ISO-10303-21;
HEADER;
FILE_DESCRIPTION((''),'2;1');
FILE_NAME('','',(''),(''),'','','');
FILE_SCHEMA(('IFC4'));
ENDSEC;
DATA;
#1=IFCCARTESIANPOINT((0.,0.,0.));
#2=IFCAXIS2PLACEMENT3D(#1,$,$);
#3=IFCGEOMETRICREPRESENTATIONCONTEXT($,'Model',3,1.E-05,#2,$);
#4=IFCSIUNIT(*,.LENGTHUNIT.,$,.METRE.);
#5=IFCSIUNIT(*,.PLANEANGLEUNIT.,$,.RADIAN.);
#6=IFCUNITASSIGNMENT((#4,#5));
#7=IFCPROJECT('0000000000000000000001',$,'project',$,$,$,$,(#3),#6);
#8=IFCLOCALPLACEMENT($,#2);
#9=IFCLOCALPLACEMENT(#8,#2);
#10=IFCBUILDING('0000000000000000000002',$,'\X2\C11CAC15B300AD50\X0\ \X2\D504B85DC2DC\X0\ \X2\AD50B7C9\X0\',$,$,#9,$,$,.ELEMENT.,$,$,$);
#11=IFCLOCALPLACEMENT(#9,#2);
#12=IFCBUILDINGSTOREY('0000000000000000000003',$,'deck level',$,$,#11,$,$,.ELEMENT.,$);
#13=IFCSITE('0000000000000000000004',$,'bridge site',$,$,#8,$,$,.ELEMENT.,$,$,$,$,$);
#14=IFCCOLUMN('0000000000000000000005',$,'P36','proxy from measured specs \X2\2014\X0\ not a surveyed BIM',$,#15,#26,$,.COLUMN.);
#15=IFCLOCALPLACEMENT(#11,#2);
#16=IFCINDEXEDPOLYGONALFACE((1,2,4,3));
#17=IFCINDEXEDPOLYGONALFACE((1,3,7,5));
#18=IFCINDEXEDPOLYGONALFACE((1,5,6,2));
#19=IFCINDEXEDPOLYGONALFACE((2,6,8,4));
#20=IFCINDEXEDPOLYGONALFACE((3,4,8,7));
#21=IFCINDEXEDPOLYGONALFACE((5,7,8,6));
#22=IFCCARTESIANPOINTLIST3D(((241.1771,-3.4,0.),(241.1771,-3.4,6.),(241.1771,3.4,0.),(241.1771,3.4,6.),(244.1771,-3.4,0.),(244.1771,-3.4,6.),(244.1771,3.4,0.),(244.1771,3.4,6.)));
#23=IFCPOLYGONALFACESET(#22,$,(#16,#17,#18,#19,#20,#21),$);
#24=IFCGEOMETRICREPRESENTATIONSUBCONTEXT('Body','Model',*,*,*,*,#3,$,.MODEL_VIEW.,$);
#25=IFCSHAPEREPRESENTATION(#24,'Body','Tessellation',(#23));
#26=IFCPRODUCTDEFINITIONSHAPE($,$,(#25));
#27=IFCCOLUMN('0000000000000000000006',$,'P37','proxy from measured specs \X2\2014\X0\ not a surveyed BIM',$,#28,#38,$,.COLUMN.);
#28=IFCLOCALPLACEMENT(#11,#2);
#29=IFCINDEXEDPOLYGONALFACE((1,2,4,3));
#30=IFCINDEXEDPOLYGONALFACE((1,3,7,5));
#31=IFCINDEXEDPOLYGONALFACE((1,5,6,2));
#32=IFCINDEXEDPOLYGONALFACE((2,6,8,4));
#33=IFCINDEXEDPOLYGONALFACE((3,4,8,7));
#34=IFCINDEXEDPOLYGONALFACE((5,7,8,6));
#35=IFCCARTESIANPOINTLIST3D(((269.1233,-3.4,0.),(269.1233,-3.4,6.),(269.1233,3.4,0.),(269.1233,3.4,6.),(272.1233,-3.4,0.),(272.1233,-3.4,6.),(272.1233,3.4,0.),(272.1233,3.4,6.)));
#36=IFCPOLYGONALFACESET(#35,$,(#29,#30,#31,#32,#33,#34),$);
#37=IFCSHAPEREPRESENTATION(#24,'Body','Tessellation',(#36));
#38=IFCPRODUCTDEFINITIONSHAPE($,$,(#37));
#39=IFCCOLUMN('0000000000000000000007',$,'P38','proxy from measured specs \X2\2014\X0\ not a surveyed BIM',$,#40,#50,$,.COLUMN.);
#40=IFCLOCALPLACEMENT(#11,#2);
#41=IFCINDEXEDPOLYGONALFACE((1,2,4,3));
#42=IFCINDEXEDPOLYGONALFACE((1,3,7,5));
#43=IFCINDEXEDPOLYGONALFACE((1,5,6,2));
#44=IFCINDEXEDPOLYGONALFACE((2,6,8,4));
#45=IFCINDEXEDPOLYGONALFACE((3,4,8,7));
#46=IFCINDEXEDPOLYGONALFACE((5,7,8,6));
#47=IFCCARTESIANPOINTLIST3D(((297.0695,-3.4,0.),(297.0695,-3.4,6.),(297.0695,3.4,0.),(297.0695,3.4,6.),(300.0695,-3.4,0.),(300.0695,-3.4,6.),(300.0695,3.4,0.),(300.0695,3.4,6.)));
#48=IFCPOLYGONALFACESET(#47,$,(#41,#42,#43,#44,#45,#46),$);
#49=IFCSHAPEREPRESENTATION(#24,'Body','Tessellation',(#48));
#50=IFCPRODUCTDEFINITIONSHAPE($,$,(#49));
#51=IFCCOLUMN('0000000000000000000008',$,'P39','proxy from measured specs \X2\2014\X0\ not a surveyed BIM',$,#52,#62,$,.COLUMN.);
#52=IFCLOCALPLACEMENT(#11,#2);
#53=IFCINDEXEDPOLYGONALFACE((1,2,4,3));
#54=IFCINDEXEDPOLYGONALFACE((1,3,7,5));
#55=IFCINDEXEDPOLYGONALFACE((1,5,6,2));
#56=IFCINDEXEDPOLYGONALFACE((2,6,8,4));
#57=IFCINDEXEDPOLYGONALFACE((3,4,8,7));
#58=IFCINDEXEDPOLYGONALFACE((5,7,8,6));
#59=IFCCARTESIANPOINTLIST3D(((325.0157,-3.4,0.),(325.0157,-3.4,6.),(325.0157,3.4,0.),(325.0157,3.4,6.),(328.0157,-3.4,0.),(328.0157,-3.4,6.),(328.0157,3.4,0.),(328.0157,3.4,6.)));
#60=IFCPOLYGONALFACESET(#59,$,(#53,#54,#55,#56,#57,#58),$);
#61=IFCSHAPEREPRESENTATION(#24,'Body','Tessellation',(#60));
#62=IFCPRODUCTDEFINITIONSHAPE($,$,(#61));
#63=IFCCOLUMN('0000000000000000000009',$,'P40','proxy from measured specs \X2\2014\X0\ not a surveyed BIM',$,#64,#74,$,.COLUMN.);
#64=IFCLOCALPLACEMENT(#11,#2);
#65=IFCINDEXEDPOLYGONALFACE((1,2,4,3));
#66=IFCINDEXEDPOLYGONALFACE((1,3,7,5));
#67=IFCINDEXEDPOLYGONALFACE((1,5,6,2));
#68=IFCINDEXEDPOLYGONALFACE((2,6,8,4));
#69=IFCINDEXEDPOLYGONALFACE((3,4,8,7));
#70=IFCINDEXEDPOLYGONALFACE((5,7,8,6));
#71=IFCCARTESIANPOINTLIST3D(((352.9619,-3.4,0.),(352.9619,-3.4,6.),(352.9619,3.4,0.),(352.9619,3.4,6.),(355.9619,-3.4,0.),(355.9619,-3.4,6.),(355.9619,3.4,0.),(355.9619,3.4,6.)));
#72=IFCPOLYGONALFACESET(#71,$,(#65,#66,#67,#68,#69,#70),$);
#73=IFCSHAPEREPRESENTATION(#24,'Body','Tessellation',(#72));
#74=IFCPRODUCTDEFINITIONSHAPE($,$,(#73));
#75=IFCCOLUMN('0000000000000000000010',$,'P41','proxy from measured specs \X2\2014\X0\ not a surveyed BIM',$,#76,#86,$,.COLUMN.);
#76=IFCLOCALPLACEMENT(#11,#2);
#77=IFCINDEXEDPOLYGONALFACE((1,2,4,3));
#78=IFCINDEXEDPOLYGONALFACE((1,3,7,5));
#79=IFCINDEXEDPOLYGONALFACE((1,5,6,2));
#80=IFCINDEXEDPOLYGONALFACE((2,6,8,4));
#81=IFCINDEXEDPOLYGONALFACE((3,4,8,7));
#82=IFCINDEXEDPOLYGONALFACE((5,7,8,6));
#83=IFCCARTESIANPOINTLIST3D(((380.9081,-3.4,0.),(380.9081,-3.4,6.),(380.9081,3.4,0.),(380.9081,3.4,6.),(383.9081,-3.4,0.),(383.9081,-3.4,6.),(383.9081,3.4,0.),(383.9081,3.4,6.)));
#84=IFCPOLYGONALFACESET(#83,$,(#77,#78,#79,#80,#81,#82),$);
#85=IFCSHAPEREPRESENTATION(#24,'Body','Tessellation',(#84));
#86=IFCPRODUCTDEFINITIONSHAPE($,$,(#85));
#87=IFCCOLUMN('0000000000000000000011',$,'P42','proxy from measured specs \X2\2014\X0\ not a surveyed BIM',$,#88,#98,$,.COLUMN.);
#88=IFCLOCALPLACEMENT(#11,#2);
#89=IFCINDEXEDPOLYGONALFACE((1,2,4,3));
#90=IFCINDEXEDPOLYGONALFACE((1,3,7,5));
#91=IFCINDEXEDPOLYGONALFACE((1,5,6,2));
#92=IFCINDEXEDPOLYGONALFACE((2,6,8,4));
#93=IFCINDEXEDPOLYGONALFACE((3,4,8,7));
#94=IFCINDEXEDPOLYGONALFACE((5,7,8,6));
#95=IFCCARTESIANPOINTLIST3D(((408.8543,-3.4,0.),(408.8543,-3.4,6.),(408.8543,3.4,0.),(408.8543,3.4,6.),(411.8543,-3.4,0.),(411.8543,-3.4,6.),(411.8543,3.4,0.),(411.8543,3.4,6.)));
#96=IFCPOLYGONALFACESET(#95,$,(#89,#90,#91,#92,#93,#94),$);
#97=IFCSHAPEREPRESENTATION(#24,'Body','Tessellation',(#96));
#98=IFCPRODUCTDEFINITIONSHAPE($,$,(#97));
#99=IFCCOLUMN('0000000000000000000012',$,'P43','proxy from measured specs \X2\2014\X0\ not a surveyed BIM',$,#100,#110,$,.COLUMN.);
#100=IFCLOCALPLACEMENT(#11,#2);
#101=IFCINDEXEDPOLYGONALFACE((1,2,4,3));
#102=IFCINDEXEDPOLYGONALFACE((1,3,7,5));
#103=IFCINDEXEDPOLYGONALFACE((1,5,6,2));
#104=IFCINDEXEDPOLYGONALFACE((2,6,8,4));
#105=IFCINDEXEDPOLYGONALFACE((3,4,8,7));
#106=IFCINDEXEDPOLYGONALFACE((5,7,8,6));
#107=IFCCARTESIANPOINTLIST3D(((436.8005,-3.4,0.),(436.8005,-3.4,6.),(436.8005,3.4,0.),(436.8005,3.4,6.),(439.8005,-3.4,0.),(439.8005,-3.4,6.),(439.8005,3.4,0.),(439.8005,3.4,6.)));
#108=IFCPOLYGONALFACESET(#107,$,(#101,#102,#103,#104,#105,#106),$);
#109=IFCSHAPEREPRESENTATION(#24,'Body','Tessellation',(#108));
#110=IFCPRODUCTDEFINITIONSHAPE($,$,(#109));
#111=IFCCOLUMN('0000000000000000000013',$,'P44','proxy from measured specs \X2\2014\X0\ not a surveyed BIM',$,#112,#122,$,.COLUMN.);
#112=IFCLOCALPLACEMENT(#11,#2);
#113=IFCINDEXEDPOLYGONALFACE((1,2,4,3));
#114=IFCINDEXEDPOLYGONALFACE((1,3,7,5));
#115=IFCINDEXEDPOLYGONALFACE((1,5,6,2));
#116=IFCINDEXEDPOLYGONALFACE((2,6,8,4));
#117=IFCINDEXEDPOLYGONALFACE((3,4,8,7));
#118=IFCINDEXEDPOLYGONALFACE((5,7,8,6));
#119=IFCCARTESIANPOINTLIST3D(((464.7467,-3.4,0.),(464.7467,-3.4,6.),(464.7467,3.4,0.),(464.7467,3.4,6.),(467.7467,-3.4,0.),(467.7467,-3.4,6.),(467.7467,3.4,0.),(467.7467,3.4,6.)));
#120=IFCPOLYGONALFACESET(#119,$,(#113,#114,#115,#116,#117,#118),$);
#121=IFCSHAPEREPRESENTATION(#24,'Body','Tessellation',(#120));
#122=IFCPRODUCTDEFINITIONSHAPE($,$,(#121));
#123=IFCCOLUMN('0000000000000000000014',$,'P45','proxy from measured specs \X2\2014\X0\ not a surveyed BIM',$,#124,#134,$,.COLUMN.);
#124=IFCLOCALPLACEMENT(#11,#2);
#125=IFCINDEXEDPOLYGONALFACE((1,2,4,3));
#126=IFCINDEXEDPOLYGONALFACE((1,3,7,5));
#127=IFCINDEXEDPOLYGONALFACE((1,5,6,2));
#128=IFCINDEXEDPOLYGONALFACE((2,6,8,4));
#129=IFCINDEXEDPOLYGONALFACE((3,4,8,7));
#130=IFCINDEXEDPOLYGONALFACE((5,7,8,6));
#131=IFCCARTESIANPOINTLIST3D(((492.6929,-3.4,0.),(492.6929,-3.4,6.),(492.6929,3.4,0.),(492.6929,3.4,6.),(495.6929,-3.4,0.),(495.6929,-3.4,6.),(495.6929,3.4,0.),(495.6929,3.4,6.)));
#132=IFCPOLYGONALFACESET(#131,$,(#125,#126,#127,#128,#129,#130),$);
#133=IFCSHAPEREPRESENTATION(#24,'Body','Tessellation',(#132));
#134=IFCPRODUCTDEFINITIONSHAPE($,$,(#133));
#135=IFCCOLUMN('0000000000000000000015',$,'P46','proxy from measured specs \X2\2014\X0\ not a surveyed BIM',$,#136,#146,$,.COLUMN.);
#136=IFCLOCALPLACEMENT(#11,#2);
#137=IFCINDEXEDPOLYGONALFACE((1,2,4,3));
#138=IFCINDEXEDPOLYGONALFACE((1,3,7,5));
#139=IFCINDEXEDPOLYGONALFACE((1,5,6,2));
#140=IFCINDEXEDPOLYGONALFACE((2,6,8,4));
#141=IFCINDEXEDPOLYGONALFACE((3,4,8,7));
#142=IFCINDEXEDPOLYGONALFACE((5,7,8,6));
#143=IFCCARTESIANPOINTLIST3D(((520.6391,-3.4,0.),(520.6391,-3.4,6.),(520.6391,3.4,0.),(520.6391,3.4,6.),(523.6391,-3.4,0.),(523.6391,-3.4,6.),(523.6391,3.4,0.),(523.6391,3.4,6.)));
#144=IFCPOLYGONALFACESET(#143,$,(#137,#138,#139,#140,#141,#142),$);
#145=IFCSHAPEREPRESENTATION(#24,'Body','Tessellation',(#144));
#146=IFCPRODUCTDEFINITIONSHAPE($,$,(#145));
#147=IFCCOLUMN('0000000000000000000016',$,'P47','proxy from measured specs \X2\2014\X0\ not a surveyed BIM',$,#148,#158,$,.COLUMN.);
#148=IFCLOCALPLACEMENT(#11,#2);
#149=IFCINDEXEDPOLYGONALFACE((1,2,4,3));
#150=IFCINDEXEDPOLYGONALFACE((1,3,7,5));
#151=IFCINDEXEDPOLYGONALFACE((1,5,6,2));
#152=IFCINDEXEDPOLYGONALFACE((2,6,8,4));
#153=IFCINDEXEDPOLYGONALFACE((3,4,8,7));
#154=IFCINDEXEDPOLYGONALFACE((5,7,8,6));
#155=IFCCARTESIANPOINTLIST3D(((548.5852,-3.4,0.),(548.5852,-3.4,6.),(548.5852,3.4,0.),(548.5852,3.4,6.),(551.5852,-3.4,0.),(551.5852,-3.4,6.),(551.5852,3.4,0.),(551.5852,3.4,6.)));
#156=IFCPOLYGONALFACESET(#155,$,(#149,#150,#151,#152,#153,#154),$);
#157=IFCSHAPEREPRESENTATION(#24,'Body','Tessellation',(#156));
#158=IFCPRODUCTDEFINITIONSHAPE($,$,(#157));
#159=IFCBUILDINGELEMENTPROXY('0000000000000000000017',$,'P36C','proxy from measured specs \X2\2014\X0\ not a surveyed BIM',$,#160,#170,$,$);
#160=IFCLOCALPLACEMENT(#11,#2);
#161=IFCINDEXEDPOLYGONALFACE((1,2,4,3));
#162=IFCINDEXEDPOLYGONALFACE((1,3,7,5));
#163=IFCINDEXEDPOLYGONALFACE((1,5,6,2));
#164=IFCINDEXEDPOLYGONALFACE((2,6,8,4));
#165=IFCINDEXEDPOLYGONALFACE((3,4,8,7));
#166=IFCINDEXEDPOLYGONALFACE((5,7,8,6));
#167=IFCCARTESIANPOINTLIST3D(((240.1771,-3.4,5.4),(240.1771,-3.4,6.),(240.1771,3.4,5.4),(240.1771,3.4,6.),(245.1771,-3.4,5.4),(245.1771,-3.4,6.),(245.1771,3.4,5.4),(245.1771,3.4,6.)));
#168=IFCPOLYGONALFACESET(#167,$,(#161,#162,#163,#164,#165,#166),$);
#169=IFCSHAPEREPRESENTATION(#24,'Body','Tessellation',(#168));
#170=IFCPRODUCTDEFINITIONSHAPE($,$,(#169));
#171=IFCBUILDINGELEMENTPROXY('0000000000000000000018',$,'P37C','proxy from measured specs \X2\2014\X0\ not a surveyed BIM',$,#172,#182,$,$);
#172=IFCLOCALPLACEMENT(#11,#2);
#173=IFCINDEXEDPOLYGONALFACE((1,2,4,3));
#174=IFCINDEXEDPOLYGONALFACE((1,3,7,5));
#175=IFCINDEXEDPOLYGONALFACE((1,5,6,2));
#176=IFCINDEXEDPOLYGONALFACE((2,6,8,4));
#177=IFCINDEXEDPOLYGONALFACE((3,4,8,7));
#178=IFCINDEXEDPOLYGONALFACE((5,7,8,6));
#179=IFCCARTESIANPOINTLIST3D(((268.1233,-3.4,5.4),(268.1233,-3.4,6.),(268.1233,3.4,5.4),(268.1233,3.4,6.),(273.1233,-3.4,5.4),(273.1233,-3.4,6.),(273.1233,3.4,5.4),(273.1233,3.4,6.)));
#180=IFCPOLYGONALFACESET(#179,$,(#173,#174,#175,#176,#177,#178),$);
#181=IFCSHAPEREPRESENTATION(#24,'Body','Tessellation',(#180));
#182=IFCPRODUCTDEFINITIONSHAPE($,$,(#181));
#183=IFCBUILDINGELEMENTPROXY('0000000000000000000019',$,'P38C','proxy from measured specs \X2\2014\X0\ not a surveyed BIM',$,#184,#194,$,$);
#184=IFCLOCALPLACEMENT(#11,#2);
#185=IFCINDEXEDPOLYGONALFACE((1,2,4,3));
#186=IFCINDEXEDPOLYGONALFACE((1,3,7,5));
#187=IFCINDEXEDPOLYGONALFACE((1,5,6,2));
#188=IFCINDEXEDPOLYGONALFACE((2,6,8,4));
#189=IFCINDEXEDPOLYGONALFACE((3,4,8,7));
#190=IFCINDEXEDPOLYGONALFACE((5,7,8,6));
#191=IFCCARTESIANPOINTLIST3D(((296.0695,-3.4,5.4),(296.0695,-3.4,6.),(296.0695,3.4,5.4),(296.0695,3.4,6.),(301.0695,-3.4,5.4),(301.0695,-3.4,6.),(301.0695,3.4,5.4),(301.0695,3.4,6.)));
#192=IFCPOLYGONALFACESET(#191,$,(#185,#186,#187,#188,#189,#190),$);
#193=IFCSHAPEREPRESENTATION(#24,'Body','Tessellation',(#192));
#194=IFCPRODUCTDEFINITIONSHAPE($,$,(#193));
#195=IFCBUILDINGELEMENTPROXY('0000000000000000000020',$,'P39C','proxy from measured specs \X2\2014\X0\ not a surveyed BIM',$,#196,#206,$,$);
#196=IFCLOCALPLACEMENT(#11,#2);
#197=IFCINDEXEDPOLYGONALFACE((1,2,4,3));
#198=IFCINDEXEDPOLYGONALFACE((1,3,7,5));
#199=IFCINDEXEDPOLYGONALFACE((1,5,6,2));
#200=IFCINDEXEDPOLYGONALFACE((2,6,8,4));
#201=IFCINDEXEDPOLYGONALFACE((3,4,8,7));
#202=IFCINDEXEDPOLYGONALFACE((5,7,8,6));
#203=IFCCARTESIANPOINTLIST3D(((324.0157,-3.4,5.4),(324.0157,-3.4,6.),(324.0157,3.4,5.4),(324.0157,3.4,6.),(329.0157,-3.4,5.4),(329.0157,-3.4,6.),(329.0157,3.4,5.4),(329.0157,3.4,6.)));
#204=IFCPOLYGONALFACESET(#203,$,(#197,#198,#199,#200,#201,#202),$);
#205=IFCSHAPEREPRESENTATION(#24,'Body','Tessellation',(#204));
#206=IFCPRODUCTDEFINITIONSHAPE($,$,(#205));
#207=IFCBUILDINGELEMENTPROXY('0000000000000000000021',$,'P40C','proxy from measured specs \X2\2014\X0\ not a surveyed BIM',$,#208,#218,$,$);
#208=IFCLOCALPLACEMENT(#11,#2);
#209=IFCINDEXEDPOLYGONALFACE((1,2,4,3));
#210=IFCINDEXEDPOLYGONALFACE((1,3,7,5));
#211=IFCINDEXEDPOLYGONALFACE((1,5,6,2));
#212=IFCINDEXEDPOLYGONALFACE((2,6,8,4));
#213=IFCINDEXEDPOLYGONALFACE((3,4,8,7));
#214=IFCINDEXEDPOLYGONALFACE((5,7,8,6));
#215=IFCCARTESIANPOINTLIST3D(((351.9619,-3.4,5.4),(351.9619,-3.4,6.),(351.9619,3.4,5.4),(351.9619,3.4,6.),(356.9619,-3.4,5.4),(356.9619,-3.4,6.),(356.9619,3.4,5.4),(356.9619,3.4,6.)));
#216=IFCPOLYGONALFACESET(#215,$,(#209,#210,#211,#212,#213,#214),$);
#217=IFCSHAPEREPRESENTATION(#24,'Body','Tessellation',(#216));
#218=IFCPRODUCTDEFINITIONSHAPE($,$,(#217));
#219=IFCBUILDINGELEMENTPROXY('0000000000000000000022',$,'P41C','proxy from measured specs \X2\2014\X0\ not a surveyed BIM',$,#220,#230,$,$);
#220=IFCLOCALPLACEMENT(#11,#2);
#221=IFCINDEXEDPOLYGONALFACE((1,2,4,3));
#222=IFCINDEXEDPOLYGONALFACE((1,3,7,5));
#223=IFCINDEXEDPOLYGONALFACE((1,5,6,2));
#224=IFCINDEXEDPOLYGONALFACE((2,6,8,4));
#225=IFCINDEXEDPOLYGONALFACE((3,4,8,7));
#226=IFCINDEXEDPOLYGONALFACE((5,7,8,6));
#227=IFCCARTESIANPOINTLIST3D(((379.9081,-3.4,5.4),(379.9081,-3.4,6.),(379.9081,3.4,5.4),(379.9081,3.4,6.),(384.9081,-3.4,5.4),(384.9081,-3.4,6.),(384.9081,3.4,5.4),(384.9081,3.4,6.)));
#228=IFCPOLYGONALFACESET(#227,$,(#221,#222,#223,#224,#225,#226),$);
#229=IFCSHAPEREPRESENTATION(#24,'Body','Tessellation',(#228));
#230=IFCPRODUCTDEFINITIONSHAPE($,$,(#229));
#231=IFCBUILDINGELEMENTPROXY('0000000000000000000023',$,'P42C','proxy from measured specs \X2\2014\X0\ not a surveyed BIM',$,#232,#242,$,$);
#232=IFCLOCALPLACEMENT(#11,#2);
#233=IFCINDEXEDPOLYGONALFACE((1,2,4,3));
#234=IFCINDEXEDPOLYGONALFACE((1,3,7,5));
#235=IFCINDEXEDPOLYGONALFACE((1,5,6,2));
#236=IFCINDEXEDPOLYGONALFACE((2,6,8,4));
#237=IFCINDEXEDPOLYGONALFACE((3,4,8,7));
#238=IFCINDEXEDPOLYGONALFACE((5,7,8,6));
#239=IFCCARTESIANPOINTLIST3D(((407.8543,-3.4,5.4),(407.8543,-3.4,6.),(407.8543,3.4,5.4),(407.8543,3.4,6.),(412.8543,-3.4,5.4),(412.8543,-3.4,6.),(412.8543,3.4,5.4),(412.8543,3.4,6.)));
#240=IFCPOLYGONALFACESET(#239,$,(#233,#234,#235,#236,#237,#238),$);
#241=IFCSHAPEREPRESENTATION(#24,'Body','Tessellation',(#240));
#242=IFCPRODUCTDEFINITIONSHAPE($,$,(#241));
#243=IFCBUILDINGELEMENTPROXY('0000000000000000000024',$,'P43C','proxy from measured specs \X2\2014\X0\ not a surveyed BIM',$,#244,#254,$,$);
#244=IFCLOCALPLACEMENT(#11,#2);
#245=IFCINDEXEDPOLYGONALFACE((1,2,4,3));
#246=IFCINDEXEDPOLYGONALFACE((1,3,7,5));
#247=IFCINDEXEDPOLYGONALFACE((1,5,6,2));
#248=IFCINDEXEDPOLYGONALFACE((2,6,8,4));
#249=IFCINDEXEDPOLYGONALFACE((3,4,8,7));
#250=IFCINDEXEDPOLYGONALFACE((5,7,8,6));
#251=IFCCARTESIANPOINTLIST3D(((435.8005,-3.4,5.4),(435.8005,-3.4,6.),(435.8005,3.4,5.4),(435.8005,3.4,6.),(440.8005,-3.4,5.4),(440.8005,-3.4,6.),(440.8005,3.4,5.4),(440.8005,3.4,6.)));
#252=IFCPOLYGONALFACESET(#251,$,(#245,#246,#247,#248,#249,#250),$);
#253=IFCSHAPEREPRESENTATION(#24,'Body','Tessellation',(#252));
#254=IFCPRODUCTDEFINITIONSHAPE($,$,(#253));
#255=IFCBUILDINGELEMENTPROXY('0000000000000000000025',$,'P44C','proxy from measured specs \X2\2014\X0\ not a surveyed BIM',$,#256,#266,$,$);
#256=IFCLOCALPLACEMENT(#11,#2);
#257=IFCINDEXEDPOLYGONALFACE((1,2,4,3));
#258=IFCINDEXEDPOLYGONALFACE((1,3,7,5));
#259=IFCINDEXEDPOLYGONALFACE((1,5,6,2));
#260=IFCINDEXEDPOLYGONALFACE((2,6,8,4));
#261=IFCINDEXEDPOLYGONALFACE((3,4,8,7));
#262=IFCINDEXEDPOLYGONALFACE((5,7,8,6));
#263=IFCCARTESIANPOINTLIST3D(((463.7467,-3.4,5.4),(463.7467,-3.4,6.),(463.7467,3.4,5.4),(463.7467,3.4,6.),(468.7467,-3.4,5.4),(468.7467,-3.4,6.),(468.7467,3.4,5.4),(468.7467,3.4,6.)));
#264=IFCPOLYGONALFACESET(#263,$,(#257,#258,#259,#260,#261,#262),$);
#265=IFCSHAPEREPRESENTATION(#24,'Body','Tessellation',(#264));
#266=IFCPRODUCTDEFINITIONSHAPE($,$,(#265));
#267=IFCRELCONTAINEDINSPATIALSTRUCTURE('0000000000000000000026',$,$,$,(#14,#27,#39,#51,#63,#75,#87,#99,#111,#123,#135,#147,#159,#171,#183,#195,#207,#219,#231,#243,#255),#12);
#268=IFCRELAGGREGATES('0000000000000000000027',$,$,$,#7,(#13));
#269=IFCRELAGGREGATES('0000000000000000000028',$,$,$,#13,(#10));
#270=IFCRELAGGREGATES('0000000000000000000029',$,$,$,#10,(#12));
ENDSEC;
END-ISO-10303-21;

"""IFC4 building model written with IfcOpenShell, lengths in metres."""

from ifc_helpers import new_model, si_unit, frame, origin, origin_2d, place, context, subcontext, project, spatial, rectangle, extrude, element, save


model = new_model("IFC4")

# Units and contexts
model_context = context("Model", 3, precision=1e-05, world=origin())
body_context = subcontext(model_context, "Body", "Model", "MODEL_VIEW")
ifc_project = project(units=[si_unit("LENGTHUNIT", "METRE"), si_unit("PLANEANGLEUNIT", "RADIAN")], contexts=[model_context])

# Site, building, storey
site_placement = place(None, origin())
site = spatial("IfcSite", under=ifc_project, at=site_placement, Name="bridge site", CompositionType="ELEMENT")
building_placement = place(site_placement, origin())
building = spatial("IfcBuilding", under=site, at=building_placement, Name="서강대교 프록시 교량", CompositionType="ELEMENT")
storey_placement = place(building_placement, origin())
storey = spatial("IfcBuildingStorey", under=building, at=storey_placement, Name="deck level", CompositionType="ELEMENT")

# Columns
for number, where, name in (
    (1, (242.6771, 0.0, 0.0), "P36"),
    (2, (270.6233, 0.0, 0.0), "P37"),
    (3, (298.5695, 0.0, 0.0), "P38"),
    (4, (326.5157, 0.0, 0.0), "P39"),
    (5, (354.4619, 0.0, 0.0), "P40"),
    (6, (382.4081, 0.0, 0.0), "P41"),
    (7, (410.3543, 0.0, 0.0), "P42"),
    (8, (438.3005, 0.0, 0.0), "P43"),
    (9, (466.2467, 0.0, 0.0), "P44"),
    (10, (494.1929, 0.0, 0.0), "P45"),
    (11, (522.1391, 0.0, 0.0), "P46"),
    (12, (550.0852, 0.0, 0.0), "P47"),
):
    element("IfcColumn", number, at=place(storey_placement, frame(where)), inside=storey, Name=name, Description="proxy from measured specs — not a surveyed BIM", PredefinedType="COLUMN", context=body_context, shape_type="SweptSolid", body=[
        extrude(rectangle(XDim=3.0, YDim=6.8, at=origin_2d()), origin(), (0.0, 0.0, 1.0), 6.0),
    ])

# Building element proxies
for number, where, name in (
    (13, (242.6771, 0.0, 5.4), "P36C"),
    (14, (270.6233, 0.0, 5.4), "P37C"),
    (15, (298.5695, 0.0, 5.4), "P38C"),
    (16, (326.5157, 0.0, 5.4), "P39C"),
    (17, (354.4619, 0.0, 5.4), "P40C"),
    (18, (382.4081, 0.0, 5.4), "P41C"),
    (19, (410.3543, 0.0, 5.4), "P42C"),
    (20, (438.3005, 0.0, 5.4), "P43C"),
    (21, (466.2467, 0.0, 5.4), "P44C"),
):
    element("IfcBuildingElementProxy", number, at=place(storey_placement, frame(where)), inside=storey, Name=name, Description="proxy from measured specs — not a surveyed BIM", context=body_context, shape_type="SweptSolid", body=[
        extrude(rectangle(XDim=5.0, YDim=6.8, at=origin_2d()), origin(), (0.0, 0.0, 1.0), 0.6),
    ])

save(model, "model.ifc")
